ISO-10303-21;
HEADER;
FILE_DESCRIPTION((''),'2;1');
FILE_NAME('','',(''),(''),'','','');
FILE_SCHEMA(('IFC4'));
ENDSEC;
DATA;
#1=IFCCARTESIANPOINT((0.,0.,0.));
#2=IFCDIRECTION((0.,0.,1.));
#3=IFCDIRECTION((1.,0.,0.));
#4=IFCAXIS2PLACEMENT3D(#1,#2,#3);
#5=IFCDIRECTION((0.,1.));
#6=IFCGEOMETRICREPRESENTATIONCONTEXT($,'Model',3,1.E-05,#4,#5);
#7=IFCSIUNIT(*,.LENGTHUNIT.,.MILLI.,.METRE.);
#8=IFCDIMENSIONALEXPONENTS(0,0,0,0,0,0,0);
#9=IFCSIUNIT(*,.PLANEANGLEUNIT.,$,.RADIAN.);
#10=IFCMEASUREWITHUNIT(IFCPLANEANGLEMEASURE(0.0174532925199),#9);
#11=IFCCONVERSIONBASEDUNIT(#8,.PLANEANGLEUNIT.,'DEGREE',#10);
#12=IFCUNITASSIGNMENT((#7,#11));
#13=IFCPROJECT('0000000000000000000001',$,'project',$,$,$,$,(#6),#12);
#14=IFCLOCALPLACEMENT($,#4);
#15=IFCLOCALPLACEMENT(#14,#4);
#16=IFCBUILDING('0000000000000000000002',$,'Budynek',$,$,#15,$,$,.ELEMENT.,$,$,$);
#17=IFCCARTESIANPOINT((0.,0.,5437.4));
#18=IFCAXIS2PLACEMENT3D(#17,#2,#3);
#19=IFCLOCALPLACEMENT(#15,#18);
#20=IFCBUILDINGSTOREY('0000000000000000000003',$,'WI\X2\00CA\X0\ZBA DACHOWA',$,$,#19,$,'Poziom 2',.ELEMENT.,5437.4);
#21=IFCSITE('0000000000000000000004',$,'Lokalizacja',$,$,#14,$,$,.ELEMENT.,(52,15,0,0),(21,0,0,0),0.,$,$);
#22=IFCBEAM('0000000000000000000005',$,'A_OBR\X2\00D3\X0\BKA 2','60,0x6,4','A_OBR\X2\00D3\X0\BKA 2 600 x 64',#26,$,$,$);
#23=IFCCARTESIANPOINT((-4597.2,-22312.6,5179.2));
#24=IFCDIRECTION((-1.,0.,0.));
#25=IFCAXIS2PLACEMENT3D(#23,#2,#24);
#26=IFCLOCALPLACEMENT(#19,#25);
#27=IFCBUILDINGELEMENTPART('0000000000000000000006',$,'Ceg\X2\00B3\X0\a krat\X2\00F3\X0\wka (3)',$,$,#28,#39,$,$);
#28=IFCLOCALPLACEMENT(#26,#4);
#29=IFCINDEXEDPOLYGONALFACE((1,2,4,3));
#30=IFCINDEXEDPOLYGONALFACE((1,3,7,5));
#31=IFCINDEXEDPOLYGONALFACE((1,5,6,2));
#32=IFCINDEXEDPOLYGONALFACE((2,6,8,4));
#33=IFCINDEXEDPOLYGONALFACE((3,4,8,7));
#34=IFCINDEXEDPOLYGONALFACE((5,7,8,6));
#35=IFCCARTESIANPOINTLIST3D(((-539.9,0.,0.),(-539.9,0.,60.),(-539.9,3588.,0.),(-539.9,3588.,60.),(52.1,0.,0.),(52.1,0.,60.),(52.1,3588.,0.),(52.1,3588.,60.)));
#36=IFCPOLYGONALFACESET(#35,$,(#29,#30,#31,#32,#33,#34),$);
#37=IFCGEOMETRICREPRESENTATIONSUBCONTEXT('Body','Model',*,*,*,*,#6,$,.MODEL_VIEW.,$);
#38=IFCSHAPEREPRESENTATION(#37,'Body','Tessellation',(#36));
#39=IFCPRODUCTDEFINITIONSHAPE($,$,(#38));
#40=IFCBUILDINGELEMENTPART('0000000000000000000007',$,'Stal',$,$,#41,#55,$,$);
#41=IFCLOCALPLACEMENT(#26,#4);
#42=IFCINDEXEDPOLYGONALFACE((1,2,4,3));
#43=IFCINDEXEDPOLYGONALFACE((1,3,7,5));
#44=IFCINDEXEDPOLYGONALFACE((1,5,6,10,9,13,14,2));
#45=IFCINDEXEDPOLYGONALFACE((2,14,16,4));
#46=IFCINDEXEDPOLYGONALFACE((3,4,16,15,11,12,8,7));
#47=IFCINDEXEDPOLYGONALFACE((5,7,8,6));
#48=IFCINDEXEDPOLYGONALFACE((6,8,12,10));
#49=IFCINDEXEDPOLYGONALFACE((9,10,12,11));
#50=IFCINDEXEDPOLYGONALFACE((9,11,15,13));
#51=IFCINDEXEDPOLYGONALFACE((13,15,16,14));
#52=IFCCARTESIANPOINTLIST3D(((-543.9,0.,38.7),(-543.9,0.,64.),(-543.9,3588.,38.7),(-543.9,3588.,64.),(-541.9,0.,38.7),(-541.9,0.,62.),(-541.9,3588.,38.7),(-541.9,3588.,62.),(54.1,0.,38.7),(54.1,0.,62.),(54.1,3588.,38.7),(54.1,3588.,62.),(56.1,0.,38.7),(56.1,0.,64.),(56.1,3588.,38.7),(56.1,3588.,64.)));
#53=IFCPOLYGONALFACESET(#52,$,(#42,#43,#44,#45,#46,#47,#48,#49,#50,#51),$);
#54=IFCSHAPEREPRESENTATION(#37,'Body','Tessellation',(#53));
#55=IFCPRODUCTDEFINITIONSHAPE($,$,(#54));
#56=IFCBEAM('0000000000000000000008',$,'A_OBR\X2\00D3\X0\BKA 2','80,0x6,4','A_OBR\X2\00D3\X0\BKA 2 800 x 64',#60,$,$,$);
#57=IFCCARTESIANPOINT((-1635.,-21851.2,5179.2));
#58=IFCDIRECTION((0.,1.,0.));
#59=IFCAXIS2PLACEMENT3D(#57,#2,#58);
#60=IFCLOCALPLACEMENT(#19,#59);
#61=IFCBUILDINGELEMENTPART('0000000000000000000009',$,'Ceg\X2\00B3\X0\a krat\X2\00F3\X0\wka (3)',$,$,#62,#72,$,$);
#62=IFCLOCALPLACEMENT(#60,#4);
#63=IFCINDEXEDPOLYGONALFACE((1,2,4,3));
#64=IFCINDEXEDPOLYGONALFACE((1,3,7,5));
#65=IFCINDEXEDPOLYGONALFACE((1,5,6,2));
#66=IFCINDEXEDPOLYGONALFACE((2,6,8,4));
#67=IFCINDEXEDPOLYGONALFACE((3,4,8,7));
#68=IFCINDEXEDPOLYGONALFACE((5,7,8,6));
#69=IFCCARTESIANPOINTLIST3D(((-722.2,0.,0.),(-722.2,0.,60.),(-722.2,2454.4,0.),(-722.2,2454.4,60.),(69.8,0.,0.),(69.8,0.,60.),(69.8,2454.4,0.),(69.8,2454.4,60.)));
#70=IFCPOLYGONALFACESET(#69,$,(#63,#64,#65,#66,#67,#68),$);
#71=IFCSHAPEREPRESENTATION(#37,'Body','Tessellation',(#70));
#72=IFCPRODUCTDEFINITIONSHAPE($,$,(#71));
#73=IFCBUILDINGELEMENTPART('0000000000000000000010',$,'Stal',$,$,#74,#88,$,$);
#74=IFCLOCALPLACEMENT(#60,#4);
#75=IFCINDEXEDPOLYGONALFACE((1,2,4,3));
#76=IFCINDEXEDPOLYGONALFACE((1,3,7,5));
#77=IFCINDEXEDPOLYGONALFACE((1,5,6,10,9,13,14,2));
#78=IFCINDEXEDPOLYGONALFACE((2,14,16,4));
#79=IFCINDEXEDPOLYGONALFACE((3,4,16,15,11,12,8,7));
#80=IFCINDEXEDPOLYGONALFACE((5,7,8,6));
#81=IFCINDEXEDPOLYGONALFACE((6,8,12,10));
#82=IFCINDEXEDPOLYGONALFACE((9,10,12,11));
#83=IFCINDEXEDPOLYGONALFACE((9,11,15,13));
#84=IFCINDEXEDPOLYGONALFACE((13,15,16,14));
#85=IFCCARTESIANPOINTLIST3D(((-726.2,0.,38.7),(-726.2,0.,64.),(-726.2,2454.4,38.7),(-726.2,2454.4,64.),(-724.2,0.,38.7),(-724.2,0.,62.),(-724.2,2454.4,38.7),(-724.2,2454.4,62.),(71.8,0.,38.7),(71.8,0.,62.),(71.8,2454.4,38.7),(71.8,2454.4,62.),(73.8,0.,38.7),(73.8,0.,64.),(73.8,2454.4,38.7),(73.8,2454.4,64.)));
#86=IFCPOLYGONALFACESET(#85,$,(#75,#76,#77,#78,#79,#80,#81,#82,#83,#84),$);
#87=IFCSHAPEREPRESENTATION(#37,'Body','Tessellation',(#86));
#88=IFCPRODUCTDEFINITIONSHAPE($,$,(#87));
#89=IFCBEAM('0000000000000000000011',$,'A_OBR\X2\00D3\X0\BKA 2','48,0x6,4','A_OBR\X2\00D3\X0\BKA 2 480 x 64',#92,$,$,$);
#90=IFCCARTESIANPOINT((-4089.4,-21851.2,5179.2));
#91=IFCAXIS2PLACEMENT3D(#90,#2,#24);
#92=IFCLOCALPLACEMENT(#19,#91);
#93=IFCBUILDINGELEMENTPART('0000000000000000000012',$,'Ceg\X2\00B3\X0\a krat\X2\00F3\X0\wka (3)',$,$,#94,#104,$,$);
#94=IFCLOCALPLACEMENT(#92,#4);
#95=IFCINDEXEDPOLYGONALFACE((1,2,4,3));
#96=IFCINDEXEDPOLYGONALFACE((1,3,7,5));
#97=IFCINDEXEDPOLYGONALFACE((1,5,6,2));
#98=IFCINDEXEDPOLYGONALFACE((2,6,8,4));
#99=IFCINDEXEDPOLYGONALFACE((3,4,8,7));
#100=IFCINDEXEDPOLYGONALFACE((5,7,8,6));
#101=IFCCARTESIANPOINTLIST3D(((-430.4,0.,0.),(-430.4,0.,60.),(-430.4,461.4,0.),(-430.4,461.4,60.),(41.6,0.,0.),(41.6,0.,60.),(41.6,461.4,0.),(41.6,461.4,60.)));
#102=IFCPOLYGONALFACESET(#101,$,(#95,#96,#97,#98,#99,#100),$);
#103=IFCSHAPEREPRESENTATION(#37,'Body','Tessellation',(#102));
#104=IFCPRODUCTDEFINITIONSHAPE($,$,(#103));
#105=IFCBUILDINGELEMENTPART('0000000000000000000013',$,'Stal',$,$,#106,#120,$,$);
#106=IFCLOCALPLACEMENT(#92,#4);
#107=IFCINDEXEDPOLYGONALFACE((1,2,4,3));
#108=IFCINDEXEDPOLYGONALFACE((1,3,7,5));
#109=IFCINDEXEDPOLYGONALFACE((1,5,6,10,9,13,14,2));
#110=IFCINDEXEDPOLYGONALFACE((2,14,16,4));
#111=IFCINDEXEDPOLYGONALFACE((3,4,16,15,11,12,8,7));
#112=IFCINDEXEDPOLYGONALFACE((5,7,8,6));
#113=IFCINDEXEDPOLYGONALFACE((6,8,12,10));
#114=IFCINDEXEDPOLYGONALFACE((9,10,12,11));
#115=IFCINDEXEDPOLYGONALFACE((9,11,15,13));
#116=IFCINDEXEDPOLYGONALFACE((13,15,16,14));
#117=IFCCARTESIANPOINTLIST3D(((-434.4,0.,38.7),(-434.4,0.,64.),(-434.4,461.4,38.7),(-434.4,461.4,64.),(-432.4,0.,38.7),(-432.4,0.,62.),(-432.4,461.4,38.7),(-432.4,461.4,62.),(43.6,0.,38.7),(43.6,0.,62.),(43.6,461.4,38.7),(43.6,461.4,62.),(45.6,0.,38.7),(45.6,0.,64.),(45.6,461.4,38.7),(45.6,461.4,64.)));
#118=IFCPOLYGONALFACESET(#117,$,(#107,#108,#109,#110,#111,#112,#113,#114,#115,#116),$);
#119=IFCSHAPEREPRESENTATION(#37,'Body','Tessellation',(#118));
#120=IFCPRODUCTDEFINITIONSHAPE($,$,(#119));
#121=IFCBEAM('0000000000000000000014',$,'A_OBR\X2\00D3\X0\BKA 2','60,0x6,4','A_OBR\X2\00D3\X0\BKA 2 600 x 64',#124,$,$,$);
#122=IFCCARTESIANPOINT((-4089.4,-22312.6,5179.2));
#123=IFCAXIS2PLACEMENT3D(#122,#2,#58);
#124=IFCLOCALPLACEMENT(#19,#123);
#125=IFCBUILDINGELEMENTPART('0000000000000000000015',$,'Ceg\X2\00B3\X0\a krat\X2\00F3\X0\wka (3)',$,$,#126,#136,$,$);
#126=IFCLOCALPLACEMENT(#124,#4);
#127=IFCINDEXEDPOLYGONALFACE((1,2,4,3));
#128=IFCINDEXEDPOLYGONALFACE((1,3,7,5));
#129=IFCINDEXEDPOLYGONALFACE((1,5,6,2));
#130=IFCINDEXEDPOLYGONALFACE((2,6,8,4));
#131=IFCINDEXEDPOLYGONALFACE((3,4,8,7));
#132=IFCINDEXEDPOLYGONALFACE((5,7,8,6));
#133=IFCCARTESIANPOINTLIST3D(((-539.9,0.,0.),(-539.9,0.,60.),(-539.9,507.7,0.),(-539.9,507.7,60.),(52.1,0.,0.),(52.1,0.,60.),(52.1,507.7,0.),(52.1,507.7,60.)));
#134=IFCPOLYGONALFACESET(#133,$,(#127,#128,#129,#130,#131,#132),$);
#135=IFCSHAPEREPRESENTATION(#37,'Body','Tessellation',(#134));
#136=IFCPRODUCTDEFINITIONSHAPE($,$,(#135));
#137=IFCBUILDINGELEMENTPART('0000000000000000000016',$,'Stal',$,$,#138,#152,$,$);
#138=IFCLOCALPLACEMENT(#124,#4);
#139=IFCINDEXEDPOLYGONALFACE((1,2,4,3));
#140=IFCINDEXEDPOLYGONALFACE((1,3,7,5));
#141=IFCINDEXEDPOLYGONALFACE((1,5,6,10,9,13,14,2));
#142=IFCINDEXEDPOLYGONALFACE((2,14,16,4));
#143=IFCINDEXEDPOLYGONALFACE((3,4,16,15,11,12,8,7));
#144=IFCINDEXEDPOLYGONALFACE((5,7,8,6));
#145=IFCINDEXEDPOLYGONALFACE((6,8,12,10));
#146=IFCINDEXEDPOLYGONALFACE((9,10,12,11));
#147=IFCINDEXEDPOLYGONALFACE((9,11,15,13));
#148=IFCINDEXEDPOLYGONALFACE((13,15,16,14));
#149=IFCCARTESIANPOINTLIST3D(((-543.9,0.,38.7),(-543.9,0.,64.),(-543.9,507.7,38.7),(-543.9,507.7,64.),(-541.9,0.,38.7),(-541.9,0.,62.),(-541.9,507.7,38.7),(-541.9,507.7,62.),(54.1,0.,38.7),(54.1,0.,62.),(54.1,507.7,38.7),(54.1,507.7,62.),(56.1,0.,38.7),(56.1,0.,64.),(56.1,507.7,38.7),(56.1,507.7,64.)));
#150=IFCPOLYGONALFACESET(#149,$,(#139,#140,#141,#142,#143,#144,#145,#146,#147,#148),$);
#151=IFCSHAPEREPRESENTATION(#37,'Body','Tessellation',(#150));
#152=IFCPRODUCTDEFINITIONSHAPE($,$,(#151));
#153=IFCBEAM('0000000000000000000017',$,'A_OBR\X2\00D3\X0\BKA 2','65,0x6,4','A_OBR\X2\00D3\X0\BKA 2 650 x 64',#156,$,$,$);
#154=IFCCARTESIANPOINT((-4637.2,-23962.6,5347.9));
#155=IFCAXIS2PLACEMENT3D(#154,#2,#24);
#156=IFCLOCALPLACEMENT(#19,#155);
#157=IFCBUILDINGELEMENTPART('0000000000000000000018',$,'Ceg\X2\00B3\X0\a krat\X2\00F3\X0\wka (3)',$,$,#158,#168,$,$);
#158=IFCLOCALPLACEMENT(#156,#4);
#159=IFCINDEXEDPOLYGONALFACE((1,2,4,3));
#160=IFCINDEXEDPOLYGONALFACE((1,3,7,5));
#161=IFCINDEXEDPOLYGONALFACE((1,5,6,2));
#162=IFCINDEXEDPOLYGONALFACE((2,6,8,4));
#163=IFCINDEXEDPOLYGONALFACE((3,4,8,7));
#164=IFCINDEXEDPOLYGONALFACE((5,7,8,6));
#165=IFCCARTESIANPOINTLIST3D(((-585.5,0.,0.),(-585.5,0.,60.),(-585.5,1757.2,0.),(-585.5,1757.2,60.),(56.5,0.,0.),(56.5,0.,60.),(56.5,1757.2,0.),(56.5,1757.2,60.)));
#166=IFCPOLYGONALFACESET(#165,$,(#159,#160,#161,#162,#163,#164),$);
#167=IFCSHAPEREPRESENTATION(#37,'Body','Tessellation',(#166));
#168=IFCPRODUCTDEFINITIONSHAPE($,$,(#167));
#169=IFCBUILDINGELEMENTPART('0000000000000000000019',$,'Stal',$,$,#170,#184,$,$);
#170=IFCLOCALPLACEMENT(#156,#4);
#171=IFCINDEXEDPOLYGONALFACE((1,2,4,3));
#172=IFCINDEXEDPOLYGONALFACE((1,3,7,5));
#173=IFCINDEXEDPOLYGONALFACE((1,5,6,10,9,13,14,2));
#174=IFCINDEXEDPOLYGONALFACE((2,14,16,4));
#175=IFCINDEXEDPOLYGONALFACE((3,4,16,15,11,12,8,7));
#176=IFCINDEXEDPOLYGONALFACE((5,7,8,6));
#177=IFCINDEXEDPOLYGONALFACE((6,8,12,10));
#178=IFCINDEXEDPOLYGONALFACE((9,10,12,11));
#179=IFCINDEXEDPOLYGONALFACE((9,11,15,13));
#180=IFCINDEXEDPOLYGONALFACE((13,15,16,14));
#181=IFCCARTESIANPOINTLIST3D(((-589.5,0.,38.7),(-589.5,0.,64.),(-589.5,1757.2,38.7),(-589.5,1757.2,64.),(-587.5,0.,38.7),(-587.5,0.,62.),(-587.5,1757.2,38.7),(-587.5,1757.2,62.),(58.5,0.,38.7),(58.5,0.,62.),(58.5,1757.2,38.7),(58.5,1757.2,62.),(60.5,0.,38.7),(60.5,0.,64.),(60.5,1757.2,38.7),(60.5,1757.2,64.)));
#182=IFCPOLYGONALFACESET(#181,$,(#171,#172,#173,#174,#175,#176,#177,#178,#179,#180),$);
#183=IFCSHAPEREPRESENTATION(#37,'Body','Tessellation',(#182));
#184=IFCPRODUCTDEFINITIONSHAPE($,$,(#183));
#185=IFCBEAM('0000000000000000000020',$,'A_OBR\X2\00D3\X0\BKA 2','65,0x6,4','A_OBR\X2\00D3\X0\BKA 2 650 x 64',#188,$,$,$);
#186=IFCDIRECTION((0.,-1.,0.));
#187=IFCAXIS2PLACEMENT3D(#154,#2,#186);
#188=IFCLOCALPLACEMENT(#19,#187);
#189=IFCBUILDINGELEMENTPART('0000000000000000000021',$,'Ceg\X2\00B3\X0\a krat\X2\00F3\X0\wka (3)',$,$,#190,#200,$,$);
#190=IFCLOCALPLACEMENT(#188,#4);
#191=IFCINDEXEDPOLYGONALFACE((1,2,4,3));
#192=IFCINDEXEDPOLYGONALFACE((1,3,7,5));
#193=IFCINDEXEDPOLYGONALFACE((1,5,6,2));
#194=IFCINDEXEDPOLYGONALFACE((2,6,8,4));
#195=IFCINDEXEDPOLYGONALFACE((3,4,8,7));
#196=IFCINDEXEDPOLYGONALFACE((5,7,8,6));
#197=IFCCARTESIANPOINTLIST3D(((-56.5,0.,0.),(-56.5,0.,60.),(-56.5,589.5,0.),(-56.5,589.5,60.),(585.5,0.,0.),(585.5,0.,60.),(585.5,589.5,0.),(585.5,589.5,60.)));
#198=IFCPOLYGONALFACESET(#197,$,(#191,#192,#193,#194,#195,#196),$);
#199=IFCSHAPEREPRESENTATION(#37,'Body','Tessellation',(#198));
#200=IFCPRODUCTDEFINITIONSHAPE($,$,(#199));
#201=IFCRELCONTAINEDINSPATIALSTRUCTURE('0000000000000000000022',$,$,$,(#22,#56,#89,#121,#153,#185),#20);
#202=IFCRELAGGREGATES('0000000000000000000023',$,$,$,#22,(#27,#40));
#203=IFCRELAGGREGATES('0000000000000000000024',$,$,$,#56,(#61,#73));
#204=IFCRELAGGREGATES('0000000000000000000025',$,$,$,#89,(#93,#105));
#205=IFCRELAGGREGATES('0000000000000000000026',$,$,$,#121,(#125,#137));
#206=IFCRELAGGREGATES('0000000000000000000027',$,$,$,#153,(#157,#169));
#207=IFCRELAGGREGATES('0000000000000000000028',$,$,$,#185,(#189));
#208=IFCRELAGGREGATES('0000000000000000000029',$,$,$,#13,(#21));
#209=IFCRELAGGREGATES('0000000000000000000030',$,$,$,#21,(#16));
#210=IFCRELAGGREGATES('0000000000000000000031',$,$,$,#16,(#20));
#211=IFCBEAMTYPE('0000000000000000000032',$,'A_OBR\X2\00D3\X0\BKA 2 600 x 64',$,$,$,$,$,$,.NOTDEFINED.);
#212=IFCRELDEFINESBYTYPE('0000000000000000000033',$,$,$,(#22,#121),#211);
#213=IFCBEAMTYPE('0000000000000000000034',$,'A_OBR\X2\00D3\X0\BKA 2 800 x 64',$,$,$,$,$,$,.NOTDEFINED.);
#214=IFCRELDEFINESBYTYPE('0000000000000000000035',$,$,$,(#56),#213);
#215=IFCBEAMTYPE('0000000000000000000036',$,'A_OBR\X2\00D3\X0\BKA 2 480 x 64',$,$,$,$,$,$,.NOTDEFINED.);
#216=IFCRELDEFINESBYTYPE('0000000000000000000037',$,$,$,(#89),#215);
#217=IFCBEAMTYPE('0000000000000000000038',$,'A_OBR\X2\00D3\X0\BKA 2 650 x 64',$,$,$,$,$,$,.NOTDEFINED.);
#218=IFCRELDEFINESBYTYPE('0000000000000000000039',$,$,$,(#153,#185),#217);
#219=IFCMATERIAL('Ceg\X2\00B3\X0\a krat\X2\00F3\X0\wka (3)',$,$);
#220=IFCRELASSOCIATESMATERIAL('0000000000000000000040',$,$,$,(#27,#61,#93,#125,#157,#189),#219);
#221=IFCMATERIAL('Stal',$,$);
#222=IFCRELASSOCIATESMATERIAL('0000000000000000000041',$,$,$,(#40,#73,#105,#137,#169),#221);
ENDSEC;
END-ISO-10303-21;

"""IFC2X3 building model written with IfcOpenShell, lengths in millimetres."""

from ifc_helpers import new_model, entity, si_unit, converted_unit, direction, frame, origin_with_axes, place, context, subcontext, project, spatial, polyline, outline, extrude, material, type_object, element, aggregate, save


model = new_model("IFC2X3")

# Units and contexts
model_context = context("Model", 3, precision=1e-05, world=origin_with_axes(), true_north=direction((0.0, 1.0)))
body_context = subcontext(model_context, "Body", "Model", "MODEL_VIEW")
ifc_project = project(units=[si_unit("LENGTHUNIT", "METRE", prefix="MILLI"), converted_unit("PLANEANGLEUNIT", "DEGREE", entity("IfcPlaneAngleMeasure", 0.0174532925199), si_unit("PLANEANGLEUNIT", "RADIAN"), dimensions=[0, 0, 0, 0, 0, 0, 0])], contexts=[model_context])

# Site, building, storey
site_placement = place(None, origin_with_axes())
site = spatial("IfcSite", under=ifc_project, at=site_placement, Name="Lokalizacja", CompositionType="ELEMENT", RefLatitude=(52, 15, 0, 0), RefLongitude=(21, 0, 0, 0), RefElevation=0.0)
building_placement = place(site_placement, origin_with_axes())
building = spatial("IfcBuilding", under=site, at=building_placement, Name="Budynek", CompositionType="ELEMENT")
storey_placement = place(building_placement, frame((0.0, 0.0, 5437.4), z_axis=(0.0, 0.0, 1.0), x_axis=(1.0, 0.0, 0.0)))
storey = spatial("IfcBuildingStorey", under=building, at=storey_placement, Name="WIÊZBA DACHOWA", LongName="Poziom 2", CompositionType="ELEMENT", Elevation=5437.4)

# Beams, building element parts
beam_type_1 = type_object("IfcBeamType", Name="A_OBRÓBKA 2 600 x 64", PredefinedType="NOTDEFINED")
beam_1_placement = place(storey_placement, frame((-4597.2, -22312.6, 5179.2), z_axis=(0.0, 0.0, 1.0), x_axis=(-1.0, 0.0, 0.0)))
beam_1 = element("IfcBeam", 1, at=beam_1_placement, inside=storey, type_object=beam_type_1, Name="A_OBRÓBKA 2", Description="60,0x6,4", ObjectType="A_OBRÓBKA 2 600 x 64")
ifc_material_1 = material(Name="Ceg³a kratówka (3)")
building_element_part_1_placement = place(beam_1_placement, origin_with_axes())
building_element_part_1 = element("IfcBuildingElementPart", 2, at=building_element_part_1_placement, material=ifc_material_1, Name="Ceg³a kratówka (3)", context=body_context, shape_type="SweptSolid", body=[
    extrude(outline(polyline([(-539.9, 0.0), (52.1, 0.0), (52.1, 60.0), (-539.9, 60.0), (-539.9, 0.0)])), frame((0.0, 3588.0, 0.0), z_axis=(0.0, -1.0, 0.0), x_axis=(1.0, 0.0, 0.0)), (0.0, 0.0, 1.0), 3588.0),
])
ifc_material_2 = material(Name="Stal")
building_element_part_2_placement = place(beam_1_placement, origin_with_axes())
building_element_part_2 = element("IfcBuildingElementPart", 3, at=building_element_part_2_placement, material=ifc_material_2, Name="Stal", context=body_context, shape_type="SweptSolid", body=[
    extrude(outline(polyline([(56.1, 64.0), (-543.9, 64.0), (-543.9, 38.7), (-541.9, 38.7), (-541.9, 62.0), (54.1, 62.0), (54.1, 38.7), (56.1, 38.7), (56.1, 64.0)])), frame((0.0, 3588.0, 0.0), z_axis=(0.0, -1.0, 0.0), x_axis=(1.0, 0.0, 0.0)), (0.0, 0.0, 1.0), 3588.0),
])
aggregate(beam_1, [building_element_part_1, building_element_part_2])
beam_type_2 = type_object("IfcBeamType", Name="A_OBRÓBKA 2 800 x 64", PredefinedType="NOTDEFINED")
beam_2_placement = place(storey_placement, frame((-1635.0, -21851.2, 5179.2), z_axis=(0.0, 0.0, 1.0), x_axis=(0.0, 1.0, 0.0)))
beam_2 = element("IfcBeam", 4, at=beam_2_placement, inside=storey, type_object=beam_type_2, Name="A_OBRÓBKA 2", Description="80,0x6,4", ObjectType="A_OBRÓBKA 2 800 x 64")
building_element_part_3_placement = place(beam_2_placement, origin_with_axes())
building_element_part_3 = element("IfcBuildingElementPart", 5, at=building_element_part_3_placement, material=ifc_material_1, Name="Ceg³a kratówka (3)", context=body_context, shape_type="SweptSolid", body=[
    extrude(outline(polyline([(-722.2, 0.0), (69.8, 0.0), (69.8, 60.0), (-722.2, 60.0), (-722.2, 0.0)])), frame((0.0, 2454.4, 0.0), z_axis=(0.0, -1.0, 0.0), x_axis=(1.0, 0.0, 0.0)), (0.0, 0.0, 1.0), 2454.4),
])
building_element_part_4_placement = place(beam_2_placement, origin_with_axes())
building_element_part_4 = element("IfcBuildingElementPart", 6, at=building_element_part_4_placement, material=ifc_material_2, Name="Stal", context=body_context, shape_type="SweptSolid", body=[
    extrude(outline(polyline([(73.8, 64.0), (-726.2, 64.0), (-726.2, 38.7), (-724.2, 38.7), (-724.2, 62.0), (71.8, 62.0), (71.8, 38.7), (73.8, 38.7), (73.8, 64.0)])), frame((0.0, 2454.4, 0.0), z_axis=(0.0, -1.0, 0.0), x_axis=(1.0, 0.0, 0.0)), (0.0, 0.0, 1.0), 2454.4),
])
aggregate(beam_2, [building_element_part_3, building_element_part_4])
beam_type_3 = type_object("IfcBeamType", Name="A_OBRÓBKA 2 480 x 64", PredefinedType="NOTDEFINED")
beam_3_placement = place(storey_placement, frame((-4089.4, -21851.2, 5179.2), z_axis=(0.0, 0.0, 1.0), x_axis=(-1.0, 0.0, 0.0)))
beam_3 = element("IfcBeam", 7, at=beam_3_placement, inside=storey, type_object=beam_type_3, Name="A_OBRÓBKA 2", Description="48,0x6,4", ObjectType="A_OBRÓBKA 2 480 x 64")
building_element_part_5_placement = place(beam_3_placement, origin_with_axes())
building_element_part_5 = element("IfcBuildingElementPart", 8, at=building_element_part_5_placement, material=ifc_material_1, Name="Ceg³a kratówka (3)", context=body_context, shape_type="SweptSolid", body=[
    extrude(outline(polyline([(-430.4, 0.0), (41.6, 0.0), (41.6, 60.0), (-430.4, 60.0), (-430.4, 0.0)])), frame((0.0, 461.4, 0.0), z_axis=(0.0, -1.0, 0.0), x_axis=(1.0, 0.0, 0.0)), (0.0, 0.0, 1.0), 461.4),
])
building_element_part_6_placement = place(beam_3_placement, origin_with_axes())
building_element_part_6 = element("IfcBuildingElementPart", 9, at=building_element_part_6_placement, material=ifc_material_2, Name="Stal", context=body_context, shape_type="SweptSolid", body=[
    extrude(outline(polyline([(45.6, 64.0), (-434.4, 64.0), (-434.4, 38.7), (-432.4, 38.7), (-432.4, 62.0), (43.6, 62.0), (43.6, 38.7), (45.6, 38.7), (45.6, 64.0)])), frame((0.0, 461.4, 0.0), z_axis=(0.0, -1.0, 0.0), x_axis=(1.0, 0.0, 0.0)), (0.0, 0.0, 1.0), 461.4),
])
aggregate(beam_3, [building_element_part_5, building_element_part_6])
beam_4_placement = place(storey_placement, frame((-4089.4, -22312.6, 5179.2), z_axis=(0.0, 0.0, 1.0), x_axis=(0.0, 1.0, 0.0)))
beam_4 = element("IfcBeam", 10, at=beam_4_placement, inside=storey, type_object=beam_type_1, Name="A_OBRÓBKA 2", Description="60,0x6,4", ObjectType="A_OBRÓBKA 2 600 x 64")
building_element_part_7_placement = place(beam_4_placement, origin_with_axes())
building_element_part_7 = element("IfcBuildingElementPart", 11, at=building_element_part_7_placement, material=ifc_material_1, Name="Ceg³a kratówka (3)", context=body_context, shape_type="SweptSolid", body=[
    extrude(outline(polyline([(-539.9, 0.0), (52.1, 0.0), (52.1, 60.0), (-539.9, 60.0), (-539.9, 0.0)])), frame((0.0, 507.7, 0.0), z_axis=(0.0, -1.0, 0.0), x_axis=(1.0, 0.0, 0.0)), (0.0, 0.0, 1.0), 507.7),
])
building_element_part_8_placement = place(beam_4_placement, origin_with_axes())
building_element_part_8 = element("IfcBuildingElementPart", 12, at=building_element_part_8_placement, material=ifc_material_2, Name="Stal", context=body_context, shape_type="SweptSolid", body=[
    extrude(outline(polyline([(56.1, 64.0), (-543.9, 64.0), (-543.9, 38.7), (-541.9, 38.7), (-541.9, 62.0), (54.1, 62.0), (54.1, 38.7), (56.1, 38.7), (56.1, 64.0)])), frame((0.0, 507.7, 0.0), z_axis=(0.0, -1.0, 0.0), x_axis=(1.0, 0.0, 0.0)), (0.0, 0.0, 1.0), 507.7),
])
aggregate(beam_4, [building_element_part_7, building_element_part_8])
beam_type_4 = type_object("IfcBeamType", Name="A_OBRÓBKA 2 650 x 64", PredefinedType="NOTDEFINED")
beam_5_placement = place(storey_placement, frame((-4637.2, -23962.6, 5347.9), z_axis=(0.0, 0.0, 1.0), x_axis=(-1.0, 0.0, 0.0)))
beam_5 = element("IfcBeam", 13, at=beam_5_placement, inside=storey, type_object=beam_type_4, Name="A_OBRÓBKA 2", Description="65,0x6,4", ObjectType="A_OBRÓBKA 2 650 x 64")
building_element_part_9_placement = place(beam_5_placement, origin_with_axes())
building_element_part_9 = element("IfcBuildingElementPart", 14, at=building_element_part_9_placement, material=ifc_material_1, Name="Ceg³a kratówka (3)", context=body_context, shape_type="SweptSolid", body=[
    extrude(outline(polyline([(-585.5, 0.0), (56.5, 0.0), (56.5, 60.0), (-585.5, 60.0), (-585.5, 0.0)])), frame((0.0, 1757.2, 0.0), z_axis=(0.0, -1.0, 0.0), x_axis=(1.0, 0.0, 0.0)), (0.0, 0.0, 1.0), 1757.2),
])
building_element_part_10_placement = place(beam_5_placement, origin_with_axes())
building_element_part_10 = element("IfcBuildingElementPart", 15, at=building_element_part_10_placement, material=ifc_material_2, Name="Stal", context=body_context, shape_type="SweptSolid", body=[
    extrude(outline(polyline([(60.5, 64.0), (-589.5, 64.0), (-589.5, 38.7), (-587.5, 38.7), (-587.5, 62.0), (58.5, 62.0), (58.5, 38.7), (60.5, 38.7), (60.5, 64.0)])), frame((0.0, 1757.2, 0.0), z_axis=(0.0, -1.0, 0.0), x_axis=(1.0, 0.0, 0.0)), (0.0, 0.0, 1.0), 1757.2),
])
aggregate(beam_5, [building_element_part_9, building_element_part_10])
beam_6_placement = place(storey_placement, frame((-4637.2, -23962.6, 5347.9), z_axis=(0.0, 0.0, 1.0), x_axis=(0.0, -1.0, 0.0)))
beam_6 = element("IfcBeam", 16, at=beam_6_placement, inside=storey, type_object=beam_type_4, Name="A_OBRÓBKA 2", Description="65,0x6,4", ObjectType="A_OBRÓBKA 2 650 x 64")
building_element_part_11_placement = place(beam_6_placement, origin_with_axes())
building_element_part_11 = element("IfcBuildingElementPart", 17, at=building_element_part_11_placement, material=ifc_material_1, Name="Ceg³a kratówka (3)", context=body_context, shape_type="SweptSolid", body=[
    extrude(outline(polyline([(585.5, 0.0), (585.5, 60.0), (-56.5, 60.0), (-56.5, 0.0), (585.5, 0.0)])), frame((0.0, 589.5, 0.0), z_axis=(0.0, -1.0, 0.0), x_axis=(1.0, 0.0, 0.0)), (0.0, 0.0, 1.0), 589.5),
])
aggregate(beam_6, [building_element_part_11])

save(model, "model.ifc")
